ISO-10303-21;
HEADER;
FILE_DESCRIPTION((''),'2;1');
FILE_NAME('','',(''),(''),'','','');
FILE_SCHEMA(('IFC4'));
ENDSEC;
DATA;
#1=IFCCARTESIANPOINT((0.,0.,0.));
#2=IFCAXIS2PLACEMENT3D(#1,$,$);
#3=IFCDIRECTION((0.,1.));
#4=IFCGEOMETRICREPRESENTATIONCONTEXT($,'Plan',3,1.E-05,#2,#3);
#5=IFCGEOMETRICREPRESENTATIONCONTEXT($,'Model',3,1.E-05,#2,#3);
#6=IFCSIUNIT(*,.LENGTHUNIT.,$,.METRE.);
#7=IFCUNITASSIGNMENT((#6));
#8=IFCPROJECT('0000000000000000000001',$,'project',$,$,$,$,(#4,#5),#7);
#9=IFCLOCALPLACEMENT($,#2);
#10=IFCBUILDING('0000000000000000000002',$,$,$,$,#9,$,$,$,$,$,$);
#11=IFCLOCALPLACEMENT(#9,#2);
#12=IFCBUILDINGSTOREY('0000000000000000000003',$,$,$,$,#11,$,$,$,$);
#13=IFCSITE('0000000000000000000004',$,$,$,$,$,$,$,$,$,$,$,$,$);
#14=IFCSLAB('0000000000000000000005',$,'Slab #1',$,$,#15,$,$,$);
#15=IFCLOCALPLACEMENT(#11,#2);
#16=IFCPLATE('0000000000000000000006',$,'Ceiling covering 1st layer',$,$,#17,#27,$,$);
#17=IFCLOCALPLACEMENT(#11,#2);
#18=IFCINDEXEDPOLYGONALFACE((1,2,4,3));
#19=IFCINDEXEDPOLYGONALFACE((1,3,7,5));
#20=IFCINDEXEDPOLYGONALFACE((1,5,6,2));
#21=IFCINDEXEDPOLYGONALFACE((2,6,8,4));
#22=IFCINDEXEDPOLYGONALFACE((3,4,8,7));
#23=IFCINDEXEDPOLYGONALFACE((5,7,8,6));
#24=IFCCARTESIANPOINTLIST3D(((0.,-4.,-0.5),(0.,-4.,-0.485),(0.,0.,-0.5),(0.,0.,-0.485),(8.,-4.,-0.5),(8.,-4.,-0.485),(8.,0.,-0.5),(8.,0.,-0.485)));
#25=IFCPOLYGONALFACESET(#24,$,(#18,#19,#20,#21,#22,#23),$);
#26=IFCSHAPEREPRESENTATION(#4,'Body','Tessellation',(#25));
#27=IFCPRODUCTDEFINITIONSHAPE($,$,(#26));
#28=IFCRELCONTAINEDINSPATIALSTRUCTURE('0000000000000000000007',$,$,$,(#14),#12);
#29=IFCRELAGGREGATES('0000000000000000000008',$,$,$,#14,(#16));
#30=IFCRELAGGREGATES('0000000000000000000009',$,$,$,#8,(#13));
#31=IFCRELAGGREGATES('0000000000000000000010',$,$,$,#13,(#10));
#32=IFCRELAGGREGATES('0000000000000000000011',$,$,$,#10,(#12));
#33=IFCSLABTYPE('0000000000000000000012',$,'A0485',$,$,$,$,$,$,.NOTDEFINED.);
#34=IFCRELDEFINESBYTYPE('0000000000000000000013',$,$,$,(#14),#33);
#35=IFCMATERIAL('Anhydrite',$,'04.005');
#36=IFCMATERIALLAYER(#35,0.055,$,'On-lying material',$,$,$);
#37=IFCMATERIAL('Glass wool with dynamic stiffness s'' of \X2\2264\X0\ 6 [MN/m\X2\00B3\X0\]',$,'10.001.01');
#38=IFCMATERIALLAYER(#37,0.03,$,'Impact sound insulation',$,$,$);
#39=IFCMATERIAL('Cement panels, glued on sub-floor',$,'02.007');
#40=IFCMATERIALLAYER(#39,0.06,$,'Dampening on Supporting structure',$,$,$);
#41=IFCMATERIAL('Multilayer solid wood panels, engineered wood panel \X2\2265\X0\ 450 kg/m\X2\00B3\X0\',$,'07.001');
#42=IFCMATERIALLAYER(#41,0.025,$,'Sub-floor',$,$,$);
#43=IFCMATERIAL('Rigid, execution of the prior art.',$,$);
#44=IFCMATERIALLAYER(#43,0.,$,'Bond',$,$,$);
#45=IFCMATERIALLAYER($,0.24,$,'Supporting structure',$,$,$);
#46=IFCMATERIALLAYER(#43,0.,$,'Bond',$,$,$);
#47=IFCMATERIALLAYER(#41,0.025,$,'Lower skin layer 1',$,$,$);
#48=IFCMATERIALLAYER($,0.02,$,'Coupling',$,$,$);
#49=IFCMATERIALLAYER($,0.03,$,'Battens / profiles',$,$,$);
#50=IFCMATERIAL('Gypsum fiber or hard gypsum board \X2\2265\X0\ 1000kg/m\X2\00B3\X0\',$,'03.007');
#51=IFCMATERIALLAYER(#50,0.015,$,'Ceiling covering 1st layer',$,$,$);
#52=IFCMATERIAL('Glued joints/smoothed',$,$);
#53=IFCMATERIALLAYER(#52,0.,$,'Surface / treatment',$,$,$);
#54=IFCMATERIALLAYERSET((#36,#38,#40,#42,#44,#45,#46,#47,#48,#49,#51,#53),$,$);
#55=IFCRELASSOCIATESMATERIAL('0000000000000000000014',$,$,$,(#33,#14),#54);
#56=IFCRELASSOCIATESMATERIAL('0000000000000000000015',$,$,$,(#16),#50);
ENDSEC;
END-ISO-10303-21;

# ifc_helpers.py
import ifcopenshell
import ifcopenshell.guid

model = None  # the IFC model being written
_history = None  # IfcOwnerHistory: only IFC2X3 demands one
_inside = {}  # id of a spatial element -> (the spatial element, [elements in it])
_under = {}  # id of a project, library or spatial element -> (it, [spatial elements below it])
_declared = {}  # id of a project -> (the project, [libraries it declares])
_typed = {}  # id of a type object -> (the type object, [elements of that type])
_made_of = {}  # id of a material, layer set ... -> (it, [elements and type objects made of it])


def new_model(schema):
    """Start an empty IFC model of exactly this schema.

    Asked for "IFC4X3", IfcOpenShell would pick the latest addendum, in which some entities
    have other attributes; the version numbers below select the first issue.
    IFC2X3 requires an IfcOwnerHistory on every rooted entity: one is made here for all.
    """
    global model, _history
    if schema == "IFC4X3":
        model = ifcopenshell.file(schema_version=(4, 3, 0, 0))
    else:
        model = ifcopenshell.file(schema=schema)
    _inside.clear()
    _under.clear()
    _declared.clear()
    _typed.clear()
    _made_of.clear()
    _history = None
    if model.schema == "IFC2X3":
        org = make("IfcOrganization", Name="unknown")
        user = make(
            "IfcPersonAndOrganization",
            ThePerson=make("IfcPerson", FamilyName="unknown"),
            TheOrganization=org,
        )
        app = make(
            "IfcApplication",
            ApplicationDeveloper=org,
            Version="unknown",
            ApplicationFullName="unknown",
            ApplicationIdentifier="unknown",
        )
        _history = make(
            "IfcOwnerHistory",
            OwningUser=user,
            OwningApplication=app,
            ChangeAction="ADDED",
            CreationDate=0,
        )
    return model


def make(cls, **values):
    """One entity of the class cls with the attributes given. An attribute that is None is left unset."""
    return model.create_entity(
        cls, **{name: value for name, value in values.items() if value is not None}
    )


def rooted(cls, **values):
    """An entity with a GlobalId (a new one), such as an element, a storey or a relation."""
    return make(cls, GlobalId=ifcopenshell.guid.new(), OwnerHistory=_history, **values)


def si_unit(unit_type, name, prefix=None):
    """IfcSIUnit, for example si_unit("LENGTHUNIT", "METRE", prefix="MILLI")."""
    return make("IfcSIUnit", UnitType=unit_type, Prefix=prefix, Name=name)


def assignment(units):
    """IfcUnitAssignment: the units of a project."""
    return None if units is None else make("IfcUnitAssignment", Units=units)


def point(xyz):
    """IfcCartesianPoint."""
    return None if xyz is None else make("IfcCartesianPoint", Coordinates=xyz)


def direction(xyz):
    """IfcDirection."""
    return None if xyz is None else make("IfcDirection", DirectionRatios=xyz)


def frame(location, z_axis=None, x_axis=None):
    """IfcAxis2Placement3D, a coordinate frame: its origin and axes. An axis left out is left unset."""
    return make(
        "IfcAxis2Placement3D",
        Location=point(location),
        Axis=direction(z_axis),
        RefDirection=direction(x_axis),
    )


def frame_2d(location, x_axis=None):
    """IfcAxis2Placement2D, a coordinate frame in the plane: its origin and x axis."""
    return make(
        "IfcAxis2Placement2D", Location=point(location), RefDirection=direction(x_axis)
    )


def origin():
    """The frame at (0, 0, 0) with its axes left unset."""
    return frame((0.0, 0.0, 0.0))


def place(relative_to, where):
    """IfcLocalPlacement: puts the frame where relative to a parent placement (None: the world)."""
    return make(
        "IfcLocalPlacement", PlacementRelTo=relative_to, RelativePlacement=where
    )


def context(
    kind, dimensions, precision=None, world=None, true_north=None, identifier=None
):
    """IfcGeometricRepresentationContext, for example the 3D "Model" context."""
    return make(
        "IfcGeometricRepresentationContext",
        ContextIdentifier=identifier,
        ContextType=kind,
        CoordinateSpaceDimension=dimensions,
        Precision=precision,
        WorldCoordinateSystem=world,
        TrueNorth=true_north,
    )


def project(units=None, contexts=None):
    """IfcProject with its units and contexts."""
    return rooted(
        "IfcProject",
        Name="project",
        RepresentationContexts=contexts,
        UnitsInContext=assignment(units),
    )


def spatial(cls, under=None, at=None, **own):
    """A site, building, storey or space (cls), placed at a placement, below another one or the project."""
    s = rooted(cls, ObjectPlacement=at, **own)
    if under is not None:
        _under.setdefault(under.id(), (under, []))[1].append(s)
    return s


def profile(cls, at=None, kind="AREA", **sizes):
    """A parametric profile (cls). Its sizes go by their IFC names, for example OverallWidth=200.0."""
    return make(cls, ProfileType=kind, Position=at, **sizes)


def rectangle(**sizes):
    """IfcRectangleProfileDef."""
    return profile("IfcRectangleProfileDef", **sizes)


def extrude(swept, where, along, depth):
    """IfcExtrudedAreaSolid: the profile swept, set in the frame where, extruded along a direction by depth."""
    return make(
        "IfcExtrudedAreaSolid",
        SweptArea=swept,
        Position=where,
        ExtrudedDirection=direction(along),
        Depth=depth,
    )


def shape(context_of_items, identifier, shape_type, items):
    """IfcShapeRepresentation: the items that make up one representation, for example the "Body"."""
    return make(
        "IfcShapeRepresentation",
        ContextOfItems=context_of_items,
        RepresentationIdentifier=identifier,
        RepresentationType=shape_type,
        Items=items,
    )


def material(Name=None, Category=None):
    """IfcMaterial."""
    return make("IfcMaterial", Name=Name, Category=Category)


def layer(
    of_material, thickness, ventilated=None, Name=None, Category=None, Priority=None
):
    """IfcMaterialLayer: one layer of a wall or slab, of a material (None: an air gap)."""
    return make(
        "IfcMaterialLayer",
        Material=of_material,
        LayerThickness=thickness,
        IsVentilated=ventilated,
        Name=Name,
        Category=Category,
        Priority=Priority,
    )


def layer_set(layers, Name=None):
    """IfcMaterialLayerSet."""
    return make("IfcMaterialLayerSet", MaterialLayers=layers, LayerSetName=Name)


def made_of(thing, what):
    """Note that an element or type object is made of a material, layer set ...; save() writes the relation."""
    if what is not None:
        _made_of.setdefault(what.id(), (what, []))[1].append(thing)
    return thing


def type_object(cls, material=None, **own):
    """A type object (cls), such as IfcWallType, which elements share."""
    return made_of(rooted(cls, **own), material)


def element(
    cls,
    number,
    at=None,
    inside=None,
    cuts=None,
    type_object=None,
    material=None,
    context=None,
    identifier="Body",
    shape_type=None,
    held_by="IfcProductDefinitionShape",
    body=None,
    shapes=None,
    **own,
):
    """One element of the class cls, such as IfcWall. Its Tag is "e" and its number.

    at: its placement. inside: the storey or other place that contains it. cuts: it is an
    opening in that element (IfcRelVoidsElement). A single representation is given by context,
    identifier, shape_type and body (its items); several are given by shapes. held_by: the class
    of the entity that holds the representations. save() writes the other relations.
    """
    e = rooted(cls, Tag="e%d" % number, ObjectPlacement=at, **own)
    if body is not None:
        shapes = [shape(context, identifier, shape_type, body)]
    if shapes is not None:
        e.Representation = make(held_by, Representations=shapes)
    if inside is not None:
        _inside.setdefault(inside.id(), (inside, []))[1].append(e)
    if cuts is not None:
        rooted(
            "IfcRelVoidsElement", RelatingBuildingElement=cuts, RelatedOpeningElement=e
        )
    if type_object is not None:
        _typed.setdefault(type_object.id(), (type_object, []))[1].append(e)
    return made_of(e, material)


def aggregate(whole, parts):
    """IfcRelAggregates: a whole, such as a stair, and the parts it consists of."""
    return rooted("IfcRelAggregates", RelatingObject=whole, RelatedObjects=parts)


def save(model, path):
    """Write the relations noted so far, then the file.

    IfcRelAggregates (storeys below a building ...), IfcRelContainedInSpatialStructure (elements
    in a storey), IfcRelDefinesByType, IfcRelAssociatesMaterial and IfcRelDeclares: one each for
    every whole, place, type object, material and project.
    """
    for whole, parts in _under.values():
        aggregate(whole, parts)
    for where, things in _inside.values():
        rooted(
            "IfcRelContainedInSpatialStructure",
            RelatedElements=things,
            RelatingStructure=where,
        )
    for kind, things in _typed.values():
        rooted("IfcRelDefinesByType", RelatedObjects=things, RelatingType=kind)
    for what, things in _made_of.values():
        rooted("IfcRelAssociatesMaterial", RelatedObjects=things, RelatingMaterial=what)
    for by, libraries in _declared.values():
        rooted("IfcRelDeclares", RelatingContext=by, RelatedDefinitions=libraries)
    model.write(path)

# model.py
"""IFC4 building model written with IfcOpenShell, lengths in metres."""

from ifc_helpers import new_model, si_unit, direction, frame, frame_2d, origin, place, context, project, spatial, rectangle, extrude, material, layer, layer_set, type_object, element, aggregate, save


model = new_model("IFC4")

# Units and contexts
plan_context = context("Plan", 3, precision=1e-05, world=origin(), true_north=direction((0.0, 1.0)))
model_context = context("Model", 3, precision=1e-05, world=origin(), true_north=direction((0.0, 1.0)))
ifc_project = project(units=[si_unit("LENGTHUNIT", "METRE")], contexts=[plan_context, model_context])

# Site, building, storey
site = spatial("IfcSite", under=ifc_project)
building_placement = place(None, origin())
building = spatial("IfcBuilding", under=site, at=building_placement)
storey_placement = place(building_placement, origin())
storey = spatial("IfcBuildingStorey", under=building, at=storey_placement)

# Slab, plate
ifc_material_1 = material(Name="Anhydrite", Category="04.005")
ifc_layer_1 = layer(ifc_material_1, 0.055, Name="On-lying material")
ifc_material_2 = material(Name="Glass wool with dynamic stiffness s' of ≤ 6 [MN/m³]", Category="10.001.01")
ifc_layer_2 = layer(ifc_material_2, 0.03, Name="Impact sound insulation")
ifc_material_3 = material(Name="Cement panels, glued on sub-floor", Category="02.007")
ifc_layer_3 = layer(ifc_material_3, 0.06, Name="Dampening on Supporting structure")
ifc_material_4 = material(Name="Multilayer solid wood panels, engineered wood panel ≥ 450 kg/m³", Category="07.001")
ifc_layer_4 = layer(ifc_material_4, 0.025, Name="Sub-floor")
ifc_material_5 = material(Name="Rigid, execution of the prior art.")
ifc_layer_5 = layer(ifc_material_5, 0.0, Name="Bond")
ifc_layer_6 = layer(None, 0.24, Name="Supporting structure")
ifc_layer_7 = layer(ifc_material_5, 0.0, Name="Bond")
ifc_layer_8 = layer(ifc_material_4, 0.025, Name="Lower skin layer 1")
ifc_layer_9 = layer(None, 0.02, Name="Coupling")
ifc_layer_10 = layer(None, 0.03, Name="Battens / profiles")
ifc_material_6 = material(Name="Gypsum fiber or hard gypsum board ≥ 1000kg/m³", Category="03.007")
ifc_layer_11 = layer(ifc_material_6, 0.015, Name="Ceiling covering 1st layer")
ifc_material_7 = material(Name="Glued joints/smoothed")
ifc_layer_12 = layer(ifc_material_7, 0.0, Name="Surface / treatment")
ifc_layer_set = layer_set([ifc_layer_1, ifc_layer_2, ifc_layer_3, ifc_layer_4, ifc_layer_5, ifc_layer_6, ifc_layer_7, ifc_layer_8, ifc_layer_9, ifc_layer_10, ifc_layer_11, ifc_layer_12])
slab_type = type_object("IfcSlabType", Name="A0485", PredefinedType="NOTDEFINED", material=ifc_layer_set)
slab_placement = place(None, frame((0.0, 0.0, 0.0), z_axis=(0.0, 0.0, -1.0), x_axis=(1.0, 0.0, 0.0)))
slab = element("IfcSlab", 1, at=slab_placement, inside=storey, type_object=slab_type, material=ifc_layer_set, Name="Slab #1")
plate_1_placement = place(slab_placement, origin())
plate_1 = element("IfcPlate", 2, at=plate_1_placement, material=ifc_material_6, Name="Ceiling covering 1st layer", context=plan_context, shape_type="SweptSolid", body=[
    extrude(rectangle(XDim=8.0, YDim=4.0, at=frame_2d((4.0, 2.0), x_axis=(1.0, 0.0))), frame((0.0, 0.0, 0.485), z_axis=(0.0, 0.0, 1.0), x_axis=(1.0, 0.0, 0.0)), (0.0, 0.0, 1.0), 0.015),
])
aggregate(slab, [plate_1])

save(model, "model.ifc")
